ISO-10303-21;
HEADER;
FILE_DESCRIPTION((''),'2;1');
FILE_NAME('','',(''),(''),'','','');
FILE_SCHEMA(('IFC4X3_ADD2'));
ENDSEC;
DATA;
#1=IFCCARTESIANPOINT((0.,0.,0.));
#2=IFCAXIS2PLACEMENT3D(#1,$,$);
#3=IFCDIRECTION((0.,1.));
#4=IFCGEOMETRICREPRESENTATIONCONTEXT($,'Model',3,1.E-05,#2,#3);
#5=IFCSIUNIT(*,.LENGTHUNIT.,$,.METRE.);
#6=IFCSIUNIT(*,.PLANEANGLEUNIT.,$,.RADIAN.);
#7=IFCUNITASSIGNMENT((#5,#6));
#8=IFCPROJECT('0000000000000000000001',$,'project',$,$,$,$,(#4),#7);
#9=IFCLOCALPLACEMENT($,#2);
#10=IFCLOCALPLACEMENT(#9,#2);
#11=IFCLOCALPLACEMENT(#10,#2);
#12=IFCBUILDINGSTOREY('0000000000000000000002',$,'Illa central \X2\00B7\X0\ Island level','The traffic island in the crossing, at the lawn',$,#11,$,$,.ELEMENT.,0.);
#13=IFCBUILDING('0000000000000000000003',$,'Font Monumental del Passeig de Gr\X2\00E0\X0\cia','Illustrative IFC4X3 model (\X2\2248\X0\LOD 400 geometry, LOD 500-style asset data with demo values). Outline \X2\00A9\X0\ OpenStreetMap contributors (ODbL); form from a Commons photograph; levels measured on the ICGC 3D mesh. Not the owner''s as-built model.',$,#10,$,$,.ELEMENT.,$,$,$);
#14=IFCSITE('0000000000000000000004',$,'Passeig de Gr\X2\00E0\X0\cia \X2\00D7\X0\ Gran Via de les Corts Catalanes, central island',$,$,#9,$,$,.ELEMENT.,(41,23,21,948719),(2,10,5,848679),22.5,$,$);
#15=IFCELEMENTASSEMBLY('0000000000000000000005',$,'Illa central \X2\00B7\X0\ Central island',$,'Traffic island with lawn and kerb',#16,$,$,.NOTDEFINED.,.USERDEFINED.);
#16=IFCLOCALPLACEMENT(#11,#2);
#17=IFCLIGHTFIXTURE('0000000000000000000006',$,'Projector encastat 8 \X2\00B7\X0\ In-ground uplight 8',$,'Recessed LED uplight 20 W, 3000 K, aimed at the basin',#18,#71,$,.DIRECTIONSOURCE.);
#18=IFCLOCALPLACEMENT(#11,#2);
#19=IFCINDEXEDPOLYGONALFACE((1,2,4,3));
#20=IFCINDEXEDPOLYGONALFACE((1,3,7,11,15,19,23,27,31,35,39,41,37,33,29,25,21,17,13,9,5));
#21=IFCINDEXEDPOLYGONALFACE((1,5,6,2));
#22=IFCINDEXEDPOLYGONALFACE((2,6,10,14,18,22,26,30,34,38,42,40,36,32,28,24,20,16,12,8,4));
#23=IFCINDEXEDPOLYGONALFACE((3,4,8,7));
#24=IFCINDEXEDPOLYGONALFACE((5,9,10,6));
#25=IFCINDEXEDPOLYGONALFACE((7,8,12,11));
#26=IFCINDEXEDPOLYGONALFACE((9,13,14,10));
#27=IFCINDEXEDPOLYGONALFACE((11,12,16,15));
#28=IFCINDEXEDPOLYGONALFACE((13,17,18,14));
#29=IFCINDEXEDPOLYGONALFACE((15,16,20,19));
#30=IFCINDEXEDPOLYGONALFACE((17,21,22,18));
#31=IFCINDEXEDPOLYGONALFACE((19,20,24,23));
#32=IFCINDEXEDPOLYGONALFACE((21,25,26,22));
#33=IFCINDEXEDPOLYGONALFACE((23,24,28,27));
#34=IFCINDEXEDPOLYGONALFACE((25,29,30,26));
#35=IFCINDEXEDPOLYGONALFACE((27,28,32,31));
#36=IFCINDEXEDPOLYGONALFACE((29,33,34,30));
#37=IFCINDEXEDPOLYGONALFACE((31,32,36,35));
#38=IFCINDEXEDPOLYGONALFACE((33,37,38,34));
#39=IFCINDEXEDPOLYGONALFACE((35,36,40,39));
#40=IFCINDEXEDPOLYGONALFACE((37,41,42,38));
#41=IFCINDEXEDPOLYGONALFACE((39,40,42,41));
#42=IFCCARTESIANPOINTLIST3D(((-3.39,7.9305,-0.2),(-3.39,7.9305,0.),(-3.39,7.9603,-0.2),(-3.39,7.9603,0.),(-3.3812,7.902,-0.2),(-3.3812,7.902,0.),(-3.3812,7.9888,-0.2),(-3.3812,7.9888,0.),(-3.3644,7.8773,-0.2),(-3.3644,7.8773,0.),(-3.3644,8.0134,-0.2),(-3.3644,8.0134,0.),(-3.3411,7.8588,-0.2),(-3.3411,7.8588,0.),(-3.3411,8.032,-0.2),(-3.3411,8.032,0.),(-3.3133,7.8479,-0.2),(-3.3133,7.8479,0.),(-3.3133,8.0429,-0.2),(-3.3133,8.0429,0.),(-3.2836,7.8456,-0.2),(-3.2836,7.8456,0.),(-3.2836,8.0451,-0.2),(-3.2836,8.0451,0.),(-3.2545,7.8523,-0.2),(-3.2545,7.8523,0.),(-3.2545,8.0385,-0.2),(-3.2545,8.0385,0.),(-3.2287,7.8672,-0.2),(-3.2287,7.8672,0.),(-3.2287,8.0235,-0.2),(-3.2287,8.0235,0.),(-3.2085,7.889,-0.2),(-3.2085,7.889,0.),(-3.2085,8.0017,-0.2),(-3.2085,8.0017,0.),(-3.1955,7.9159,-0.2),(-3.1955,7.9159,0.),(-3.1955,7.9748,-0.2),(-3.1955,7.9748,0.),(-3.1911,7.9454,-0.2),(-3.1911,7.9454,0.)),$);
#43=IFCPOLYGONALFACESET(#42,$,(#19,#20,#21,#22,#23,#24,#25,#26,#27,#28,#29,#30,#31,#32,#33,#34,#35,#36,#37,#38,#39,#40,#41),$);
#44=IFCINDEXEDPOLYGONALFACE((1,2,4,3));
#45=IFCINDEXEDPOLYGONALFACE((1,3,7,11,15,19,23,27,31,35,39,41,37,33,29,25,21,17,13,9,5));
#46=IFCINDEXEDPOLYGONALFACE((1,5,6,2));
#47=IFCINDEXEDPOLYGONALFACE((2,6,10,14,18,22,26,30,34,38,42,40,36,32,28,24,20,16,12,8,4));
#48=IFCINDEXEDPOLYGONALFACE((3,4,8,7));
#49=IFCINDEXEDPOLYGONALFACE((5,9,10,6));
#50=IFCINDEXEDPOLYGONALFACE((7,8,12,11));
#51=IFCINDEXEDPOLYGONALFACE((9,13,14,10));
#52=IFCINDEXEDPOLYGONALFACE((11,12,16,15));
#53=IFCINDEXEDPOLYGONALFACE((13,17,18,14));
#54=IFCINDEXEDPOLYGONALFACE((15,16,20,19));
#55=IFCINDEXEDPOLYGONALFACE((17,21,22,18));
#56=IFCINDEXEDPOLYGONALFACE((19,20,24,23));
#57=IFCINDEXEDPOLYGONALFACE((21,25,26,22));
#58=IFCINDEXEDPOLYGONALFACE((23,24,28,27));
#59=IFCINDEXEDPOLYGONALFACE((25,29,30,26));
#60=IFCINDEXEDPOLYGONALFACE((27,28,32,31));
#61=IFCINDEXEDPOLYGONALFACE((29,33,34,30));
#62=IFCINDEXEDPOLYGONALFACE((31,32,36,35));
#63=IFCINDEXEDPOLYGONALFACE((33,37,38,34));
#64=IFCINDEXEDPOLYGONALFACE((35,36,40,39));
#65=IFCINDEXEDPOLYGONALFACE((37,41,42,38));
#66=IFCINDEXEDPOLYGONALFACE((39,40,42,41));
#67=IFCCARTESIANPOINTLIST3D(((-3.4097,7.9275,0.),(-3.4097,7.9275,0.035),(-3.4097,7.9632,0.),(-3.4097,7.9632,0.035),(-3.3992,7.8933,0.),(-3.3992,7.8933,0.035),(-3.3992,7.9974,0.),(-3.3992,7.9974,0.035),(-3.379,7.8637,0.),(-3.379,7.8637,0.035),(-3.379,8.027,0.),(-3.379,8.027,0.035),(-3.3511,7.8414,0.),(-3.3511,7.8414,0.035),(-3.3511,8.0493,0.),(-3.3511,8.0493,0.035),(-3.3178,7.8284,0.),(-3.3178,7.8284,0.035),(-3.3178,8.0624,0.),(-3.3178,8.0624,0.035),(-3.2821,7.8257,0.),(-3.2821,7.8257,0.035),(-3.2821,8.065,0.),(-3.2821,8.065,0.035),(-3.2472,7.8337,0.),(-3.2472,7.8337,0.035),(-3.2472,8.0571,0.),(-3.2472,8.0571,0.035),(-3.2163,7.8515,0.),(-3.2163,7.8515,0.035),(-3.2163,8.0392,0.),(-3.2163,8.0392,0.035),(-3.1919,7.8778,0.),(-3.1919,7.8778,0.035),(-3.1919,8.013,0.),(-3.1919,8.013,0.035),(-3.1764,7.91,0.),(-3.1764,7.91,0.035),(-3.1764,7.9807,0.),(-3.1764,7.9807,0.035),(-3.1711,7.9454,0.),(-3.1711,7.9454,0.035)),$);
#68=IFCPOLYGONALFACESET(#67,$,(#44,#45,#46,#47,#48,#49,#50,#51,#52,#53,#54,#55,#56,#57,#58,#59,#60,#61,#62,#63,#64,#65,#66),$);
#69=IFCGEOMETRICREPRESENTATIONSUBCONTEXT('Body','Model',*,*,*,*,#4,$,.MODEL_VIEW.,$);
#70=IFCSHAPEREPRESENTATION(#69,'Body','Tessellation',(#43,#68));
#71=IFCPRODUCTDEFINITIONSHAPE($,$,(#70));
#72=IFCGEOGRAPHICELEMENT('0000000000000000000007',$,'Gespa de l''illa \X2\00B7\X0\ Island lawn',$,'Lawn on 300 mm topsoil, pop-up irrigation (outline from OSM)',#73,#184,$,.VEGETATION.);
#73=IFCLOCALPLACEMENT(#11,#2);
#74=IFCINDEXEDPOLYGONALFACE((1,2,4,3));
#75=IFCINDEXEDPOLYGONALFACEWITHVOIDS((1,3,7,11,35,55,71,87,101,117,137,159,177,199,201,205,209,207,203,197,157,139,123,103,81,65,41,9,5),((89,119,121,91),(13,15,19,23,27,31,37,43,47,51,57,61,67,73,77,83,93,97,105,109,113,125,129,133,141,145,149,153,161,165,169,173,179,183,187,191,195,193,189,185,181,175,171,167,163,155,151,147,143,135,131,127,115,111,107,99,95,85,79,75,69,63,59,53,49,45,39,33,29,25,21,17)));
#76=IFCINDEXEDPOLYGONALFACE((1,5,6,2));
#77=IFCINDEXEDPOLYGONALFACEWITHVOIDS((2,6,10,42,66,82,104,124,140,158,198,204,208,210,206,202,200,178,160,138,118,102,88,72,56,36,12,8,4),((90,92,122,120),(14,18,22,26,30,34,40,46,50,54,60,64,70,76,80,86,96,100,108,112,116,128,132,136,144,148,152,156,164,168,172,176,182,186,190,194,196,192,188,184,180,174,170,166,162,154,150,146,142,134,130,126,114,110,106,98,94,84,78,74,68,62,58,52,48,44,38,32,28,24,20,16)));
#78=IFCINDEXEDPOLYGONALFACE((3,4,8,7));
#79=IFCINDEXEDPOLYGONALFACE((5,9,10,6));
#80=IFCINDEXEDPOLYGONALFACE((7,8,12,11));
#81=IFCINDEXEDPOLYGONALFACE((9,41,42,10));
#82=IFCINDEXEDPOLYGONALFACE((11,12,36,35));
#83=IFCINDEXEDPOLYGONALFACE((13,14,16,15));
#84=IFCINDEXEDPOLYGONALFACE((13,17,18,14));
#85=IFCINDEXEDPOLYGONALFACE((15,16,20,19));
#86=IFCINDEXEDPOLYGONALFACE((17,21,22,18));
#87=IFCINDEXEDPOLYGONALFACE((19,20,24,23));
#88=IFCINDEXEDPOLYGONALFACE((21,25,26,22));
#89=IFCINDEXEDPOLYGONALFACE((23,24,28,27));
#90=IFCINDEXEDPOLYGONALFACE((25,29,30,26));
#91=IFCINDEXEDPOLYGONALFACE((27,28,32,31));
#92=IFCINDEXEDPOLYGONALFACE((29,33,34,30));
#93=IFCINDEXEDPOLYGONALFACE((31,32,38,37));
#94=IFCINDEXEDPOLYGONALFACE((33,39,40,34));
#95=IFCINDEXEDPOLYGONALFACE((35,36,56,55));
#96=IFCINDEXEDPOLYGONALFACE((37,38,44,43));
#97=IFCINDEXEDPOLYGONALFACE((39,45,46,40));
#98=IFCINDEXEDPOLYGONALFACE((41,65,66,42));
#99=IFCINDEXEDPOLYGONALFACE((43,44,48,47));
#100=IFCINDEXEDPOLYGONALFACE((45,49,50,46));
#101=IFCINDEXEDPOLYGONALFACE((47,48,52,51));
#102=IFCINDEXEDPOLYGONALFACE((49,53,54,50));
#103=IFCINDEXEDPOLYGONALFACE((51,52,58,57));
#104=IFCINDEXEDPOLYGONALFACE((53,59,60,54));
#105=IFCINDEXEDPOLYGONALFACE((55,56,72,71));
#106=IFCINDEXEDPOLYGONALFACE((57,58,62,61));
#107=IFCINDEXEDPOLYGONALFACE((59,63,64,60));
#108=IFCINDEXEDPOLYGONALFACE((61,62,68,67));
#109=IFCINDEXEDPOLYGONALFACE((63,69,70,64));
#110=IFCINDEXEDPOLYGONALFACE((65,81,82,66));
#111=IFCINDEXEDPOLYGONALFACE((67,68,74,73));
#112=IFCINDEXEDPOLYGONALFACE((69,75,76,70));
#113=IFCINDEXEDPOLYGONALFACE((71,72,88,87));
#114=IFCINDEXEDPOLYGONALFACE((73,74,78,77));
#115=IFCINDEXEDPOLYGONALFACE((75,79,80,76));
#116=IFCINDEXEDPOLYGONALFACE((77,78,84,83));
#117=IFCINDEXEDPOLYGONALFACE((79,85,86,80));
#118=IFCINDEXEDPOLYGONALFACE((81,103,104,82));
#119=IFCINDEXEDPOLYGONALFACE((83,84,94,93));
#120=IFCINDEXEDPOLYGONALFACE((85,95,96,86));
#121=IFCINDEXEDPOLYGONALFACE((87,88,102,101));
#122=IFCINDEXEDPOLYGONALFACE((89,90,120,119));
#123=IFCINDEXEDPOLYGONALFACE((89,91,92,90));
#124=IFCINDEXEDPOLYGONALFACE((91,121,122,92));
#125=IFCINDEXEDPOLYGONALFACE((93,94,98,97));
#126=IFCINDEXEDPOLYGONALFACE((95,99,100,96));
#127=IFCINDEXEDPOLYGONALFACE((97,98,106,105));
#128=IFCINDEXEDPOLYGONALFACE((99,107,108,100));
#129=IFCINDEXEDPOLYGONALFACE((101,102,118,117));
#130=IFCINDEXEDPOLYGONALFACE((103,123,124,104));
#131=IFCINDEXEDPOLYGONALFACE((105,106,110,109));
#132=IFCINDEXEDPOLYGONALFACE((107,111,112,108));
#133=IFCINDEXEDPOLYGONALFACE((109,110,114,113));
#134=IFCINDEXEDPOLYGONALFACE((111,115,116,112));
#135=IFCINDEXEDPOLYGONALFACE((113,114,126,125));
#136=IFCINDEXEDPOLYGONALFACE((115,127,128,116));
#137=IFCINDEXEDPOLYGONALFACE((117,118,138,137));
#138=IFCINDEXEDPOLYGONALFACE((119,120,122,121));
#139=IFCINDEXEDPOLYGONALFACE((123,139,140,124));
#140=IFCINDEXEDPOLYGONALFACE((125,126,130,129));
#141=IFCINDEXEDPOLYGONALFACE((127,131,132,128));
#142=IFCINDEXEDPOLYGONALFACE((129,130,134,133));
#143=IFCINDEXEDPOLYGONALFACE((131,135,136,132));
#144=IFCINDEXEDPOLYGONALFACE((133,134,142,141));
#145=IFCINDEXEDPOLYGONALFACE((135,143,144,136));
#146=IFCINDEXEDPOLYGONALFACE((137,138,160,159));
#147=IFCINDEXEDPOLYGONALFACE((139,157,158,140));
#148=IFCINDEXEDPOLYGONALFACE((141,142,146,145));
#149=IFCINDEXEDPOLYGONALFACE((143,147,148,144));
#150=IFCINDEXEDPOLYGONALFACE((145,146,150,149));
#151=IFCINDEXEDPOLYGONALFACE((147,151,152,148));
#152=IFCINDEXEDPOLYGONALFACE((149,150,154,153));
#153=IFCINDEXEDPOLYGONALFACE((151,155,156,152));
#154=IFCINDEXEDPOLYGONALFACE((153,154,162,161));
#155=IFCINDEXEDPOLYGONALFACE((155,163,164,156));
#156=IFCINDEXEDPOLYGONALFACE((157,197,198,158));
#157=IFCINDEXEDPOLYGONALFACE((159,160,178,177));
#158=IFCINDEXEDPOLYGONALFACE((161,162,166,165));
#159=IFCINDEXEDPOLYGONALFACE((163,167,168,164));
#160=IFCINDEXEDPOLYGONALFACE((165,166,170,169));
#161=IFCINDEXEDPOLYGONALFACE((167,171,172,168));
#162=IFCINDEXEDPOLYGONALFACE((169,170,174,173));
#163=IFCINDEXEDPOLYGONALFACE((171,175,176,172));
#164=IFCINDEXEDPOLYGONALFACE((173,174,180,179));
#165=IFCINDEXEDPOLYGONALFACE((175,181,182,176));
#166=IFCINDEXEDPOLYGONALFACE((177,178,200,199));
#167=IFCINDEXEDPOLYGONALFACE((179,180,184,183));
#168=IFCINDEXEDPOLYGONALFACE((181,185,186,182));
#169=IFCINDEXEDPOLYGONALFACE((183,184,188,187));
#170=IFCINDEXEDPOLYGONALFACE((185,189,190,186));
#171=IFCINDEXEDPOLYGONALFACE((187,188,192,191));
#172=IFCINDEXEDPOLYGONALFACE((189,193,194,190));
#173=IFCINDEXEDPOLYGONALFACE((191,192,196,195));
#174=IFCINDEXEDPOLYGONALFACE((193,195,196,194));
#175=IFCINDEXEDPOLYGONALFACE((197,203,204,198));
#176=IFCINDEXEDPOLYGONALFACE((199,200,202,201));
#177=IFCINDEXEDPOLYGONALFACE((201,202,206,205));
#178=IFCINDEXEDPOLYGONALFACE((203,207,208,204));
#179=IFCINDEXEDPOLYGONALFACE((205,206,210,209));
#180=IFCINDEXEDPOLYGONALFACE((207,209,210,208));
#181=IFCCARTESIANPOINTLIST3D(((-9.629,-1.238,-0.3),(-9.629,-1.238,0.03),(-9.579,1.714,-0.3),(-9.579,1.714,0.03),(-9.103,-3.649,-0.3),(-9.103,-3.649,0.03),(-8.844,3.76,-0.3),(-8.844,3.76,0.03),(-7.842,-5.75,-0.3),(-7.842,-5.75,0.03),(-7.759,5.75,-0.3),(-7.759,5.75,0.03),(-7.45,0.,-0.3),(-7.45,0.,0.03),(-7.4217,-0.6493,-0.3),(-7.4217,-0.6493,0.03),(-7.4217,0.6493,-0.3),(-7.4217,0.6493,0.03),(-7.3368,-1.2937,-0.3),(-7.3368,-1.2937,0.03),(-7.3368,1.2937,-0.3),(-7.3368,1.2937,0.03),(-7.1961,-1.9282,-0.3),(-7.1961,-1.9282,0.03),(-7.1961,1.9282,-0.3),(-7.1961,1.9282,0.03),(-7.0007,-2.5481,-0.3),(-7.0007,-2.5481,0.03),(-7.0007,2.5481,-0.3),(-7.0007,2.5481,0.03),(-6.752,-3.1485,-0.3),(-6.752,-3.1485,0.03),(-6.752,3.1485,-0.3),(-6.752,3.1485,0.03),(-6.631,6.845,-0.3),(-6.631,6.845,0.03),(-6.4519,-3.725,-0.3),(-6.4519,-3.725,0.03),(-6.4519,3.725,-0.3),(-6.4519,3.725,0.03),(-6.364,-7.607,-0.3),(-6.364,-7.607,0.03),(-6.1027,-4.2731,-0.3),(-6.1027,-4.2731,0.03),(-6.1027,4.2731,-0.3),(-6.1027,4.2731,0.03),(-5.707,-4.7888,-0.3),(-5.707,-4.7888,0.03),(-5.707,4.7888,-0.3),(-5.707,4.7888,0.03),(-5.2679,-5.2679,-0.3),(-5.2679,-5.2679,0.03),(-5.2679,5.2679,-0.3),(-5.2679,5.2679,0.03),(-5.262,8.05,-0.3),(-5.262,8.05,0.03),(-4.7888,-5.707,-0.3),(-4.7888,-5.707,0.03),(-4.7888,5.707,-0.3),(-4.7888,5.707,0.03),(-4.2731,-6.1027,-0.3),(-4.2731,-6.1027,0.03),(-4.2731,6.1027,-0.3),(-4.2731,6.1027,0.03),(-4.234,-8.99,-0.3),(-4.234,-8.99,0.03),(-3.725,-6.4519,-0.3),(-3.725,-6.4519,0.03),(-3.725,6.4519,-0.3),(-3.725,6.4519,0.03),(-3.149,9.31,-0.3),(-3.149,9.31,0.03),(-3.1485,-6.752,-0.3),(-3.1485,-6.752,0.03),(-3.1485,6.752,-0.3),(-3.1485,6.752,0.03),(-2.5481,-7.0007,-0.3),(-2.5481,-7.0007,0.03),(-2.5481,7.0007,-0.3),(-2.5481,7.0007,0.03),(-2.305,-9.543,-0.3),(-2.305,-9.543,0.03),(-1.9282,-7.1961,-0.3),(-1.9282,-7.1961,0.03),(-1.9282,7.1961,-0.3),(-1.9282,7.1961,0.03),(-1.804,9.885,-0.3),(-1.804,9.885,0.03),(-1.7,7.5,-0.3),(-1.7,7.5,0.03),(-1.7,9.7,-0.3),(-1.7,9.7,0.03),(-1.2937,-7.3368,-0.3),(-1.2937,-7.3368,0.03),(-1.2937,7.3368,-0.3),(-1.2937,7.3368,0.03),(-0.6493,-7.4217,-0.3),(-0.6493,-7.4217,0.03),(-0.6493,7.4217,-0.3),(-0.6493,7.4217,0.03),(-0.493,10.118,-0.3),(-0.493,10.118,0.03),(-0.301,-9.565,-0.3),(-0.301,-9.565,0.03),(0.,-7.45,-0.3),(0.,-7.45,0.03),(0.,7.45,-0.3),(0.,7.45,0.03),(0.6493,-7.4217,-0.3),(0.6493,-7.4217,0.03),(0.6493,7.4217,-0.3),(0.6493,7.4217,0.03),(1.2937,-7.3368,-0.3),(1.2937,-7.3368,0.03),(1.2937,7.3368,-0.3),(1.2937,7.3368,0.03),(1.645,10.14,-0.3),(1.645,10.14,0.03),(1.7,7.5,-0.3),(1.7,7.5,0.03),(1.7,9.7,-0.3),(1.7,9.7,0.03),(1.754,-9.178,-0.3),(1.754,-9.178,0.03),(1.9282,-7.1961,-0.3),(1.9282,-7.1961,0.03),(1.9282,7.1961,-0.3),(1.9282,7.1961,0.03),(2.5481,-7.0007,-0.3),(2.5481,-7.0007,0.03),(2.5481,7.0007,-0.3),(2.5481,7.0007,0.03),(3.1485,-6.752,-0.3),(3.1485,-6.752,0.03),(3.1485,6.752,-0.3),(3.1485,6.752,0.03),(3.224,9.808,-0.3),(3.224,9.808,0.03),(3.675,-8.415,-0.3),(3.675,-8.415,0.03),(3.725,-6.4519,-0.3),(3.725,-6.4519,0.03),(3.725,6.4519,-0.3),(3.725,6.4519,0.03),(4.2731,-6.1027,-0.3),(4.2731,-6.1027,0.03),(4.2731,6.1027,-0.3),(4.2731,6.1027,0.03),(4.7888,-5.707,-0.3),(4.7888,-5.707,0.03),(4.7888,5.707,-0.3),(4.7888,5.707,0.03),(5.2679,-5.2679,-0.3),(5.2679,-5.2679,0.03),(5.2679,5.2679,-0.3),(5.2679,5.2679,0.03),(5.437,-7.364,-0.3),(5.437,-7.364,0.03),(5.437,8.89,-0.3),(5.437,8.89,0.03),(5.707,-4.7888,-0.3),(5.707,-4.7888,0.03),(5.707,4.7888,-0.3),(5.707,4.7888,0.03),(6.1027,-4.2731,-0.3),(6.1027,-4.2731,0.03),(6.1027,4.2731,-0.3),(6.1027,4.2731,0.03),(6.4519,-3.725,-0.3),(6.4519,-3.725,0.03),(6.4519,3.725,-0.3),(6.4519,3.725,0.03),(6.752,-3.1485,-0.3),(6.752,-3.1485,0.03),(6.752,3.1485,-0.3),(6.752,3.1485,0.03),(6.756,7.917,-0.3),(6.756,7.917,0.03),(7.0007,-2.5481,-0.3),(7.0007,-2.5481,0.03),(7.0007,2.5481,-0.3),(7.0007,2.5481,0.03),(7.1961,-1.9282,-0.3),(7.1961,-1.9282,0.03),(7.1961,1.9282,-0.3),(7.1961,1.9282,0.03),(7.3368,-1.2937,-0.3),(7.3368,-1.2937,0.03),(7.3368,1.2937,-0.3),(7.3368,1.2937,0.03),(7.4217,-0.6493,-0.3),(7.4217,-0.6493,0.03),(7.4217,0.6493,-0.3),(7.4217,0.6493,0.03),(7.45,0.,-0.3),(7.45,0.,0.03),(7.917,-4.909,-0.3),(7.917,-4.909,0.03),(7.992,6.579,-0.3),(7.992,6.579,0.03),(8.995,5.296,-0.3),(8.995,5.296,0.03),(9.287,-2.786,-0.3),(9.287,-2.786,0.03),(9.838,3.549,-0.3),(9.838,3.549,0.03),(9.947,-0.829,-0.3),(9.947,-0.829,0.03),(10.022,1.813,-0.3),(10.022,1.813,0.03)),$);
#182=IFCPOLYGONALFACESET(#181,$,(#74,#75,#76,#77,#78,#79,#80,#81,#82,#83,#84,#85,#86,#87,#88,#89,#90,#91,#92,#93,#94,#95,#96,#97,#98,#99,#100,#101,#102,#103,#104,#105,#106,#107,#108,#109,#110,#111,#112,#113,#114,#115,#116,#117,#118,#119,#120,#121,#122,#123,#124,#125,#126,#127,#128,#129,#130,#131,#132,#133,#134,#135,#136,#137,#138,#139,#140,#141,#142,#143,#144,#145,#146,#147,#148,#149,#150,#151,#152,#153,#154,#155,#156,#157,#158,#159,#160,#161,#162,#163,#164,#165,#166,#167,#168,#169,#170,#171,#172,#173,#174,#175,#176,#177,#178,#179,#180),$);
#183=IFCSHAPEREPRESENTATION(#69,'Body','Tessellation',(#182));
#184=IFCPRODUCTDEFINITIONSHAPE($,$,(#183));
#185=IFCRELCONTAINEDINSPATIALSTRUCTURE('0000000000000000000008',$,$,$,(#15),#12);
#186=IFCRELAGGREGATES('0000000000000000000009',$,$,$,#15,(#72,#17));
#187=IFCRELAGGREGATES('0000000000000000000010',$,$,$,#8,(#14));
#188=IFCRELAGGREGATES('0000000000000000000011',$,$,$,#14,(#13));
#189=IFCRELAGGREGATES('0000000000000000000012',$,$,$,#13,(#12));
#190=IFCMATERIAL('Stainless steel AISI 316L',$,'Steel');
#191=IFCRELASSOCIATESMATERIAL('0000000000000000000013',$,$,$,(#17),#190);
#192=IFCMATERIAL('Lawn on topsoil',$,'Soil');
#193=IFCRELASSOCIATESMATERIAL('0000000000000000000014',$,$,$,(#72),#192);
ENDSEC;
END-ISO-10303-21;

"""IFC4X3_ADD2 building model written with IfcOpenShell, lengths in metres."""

from ifc_helpers import new_model, si_unit, direction, frame, origin, origin_2d_with_axis, place, context, subcontext, project, spatial, polyline, circle, outline, extrude, material, element, aggregate, save


model = new_model("IFC4X3_ADD2")

# Units and contexts
model_context = context("Model", 3, precision=1e-05, world=origin(), true_north=direction((0.0, 1.0)))
body_context = subcontext(model_context, "Body", "Model", "MODEL_VIEW")
ifc_project = project(units=[si_unit("LENGTHUNIT", "METRE"), si_unit("PLANEANGLEUNIT", "RADIAN")], contexts=[model_context])

# Site, building, storey
site_placement = place(None, origin())
site = spatial("IfcSite", under=ifc_project, at=site_placement, Name="Passeig de Gràcia × Gran Via de les Corts Catalanes, central island", CompositionType="ELEMENT", RefLatitude=(41, 23, 21, 948719), RefLongitude=(2, 10, 5, 848679), RefElevation=22.5)
building_placement = place(site_placement, origin())
building = spatial("IfcBuilding", under=site, at=building_placement, Name="Font Monumental del Passeig de Gràcia", Description="Illustrative IFC4X3 model (≈LOD 400 geometry, LOD 500-style asset data with demo values). Outline © OpenStreetMap contributors (ODbL); form from a Commons photograph; levels measured on the ICGC 3D mesh. Not the owner's as-built model.", CompositionType="ELEMENT")
storey_placement = place(building_placement, origin())
storey = spatial("IfcBuildingStorey", under=building, at=storey_placement, Name="Illa central · Island level", Description="The traffic island in the crossing, at the lawn", CompositionType="ELEMENT", Elevation=0.0)

# Shared definitions
ifc_material_1 = material(Name="Stainless steel AISI 316L", Category="Steel")

# Element assembly, light fixture
assembly_1_placement = place(building_placement, origin())
assembly_1 = element("IfcElementAssembly", 1, at=assembly_1_placement, inside=storey, Name="Illa central · Central island", ObjectType="Traffic island with lawn and kerb", AssemblyPlace="NOTDEFINED", PredefinedType="USERDEFINED")
light_fixture_1_placement = place(building_placement, origin())
light_fixture_1 = element("IfcLightFixture", 2, at=light_fixture_1_placement, material=ifc_material_1, Name="Projector encastat 8 · In-ground uplight 8", ObjectType="Recessed LED uplight 20 W, 3000 K, aimed at the basin", PredefinedType="DIRECTIONSOURCE", context=body_context, shape_type="SweptSolid", body=[
    extrude(circle(Radius=0.1, at=origin_2d_with_axis()), frame((-3.2911, 7.9454, -0.2)), (0.0, 0.0, 1.0), 0.2),
    extrude(circle(Radius=0.12, at=origin_2d_with_axis()), frame((-3.2911, 7.9454, 0.0)), (0.0, 0.0, 1.0), 0.035),
])

# Geographic element
ifc_material_2 = material(Name="Lawn on topsoil", Category="Soil")
geographic_element_placement = place(building_placement, origin())
geographic_element = element("IfcGeographicElement", 3, at=geographic_element_placement, material=ifc_material_2, Name="Gespa de l'illa · Island lawn", ObjectType="Lawn on 300 mm topsoil, pop-up irrigation (outline from OSM)", PredefinedType="VEGETATION", context=body_context, shape_type="SweptSolid", body=[
    extrude(outline(polyline([(-1.804, 9.885), (-3.149, 9.31), (-5.262, 8.05), (-6.631, 6.845), (-7.759, 5.75), (-8.844, 3.76), (-9.579, 1.714), (-9.629, -1.238), (-9.103, -3.649), (-7.842, -5.75), (-6.364, -7.607), (-4.234, -8.99), (-2.305, -9.543), (-0.301, -9.565), (1.754, -9.178), (3.675, -8.415), (5.437, -7.364), (7.917, -4.909), (9.287, -2.786), (9.947, -0.829), (10.022, 1.813), (9.838, 3.549), (8.995, 5.296), (7.992, 6.579), (6.756, 7.917), (5.437, 8.89), (3.224, 9.808), (1.645, 10.14), (-0.493, 10.118), (-1.804, 9.885)]), holes=[polyline([(-0.6493, 7.4217), (-1.2937, 7.3368), (-1.9282, 7.1961), (-2.5481, 7.0007), (-3.1485, 6.752), (-3.725, 6.4519), (-4.2731, 6.1027), (-4.7888, 5.707), (-5.2679, 5.2679), (-5.707, 4.7888), (-6.1027, 4.2731), (-6.4519, 3.725), (-6.752, 3.1485), (-7.0007, 2.5481), (-7.1961, 1.9282), (-7.3368, 1.2937), (-7.4217, 0.6493), (-7.45, 0.0), (-7.4217, -0.6493), (-7.3368, -1.2937), (-7.1961, -1.9282), (-7.0007, -2.5481), (-6.752, -3.1485), (-6.4519, -3.725), (-6.1027, -4.2731), (-5.707, -4.7888), (-5.2679, -5.2679), (-4.7888, -5.707), (-4.2731, -6.1027), (-3.725, -6.4519), (-3.1485, -6.752), (-2.5481, -7.0007), (-1.9282, -7.1961), (-1.2937, -7.3368), (-0.6493, -7.4217), (0.0, -7.45), (0.6493, -7.4217), (1.2937, -7.3368), (1.9282, -7.1961), (2.5481, -7.0007), (3.1485, -6.752), (3.725, -6.4519), (4.2731, -6.1027), (4.7888, -5.707), (5.2679, -5.2679), (5.707, -4.7888), (6.1027, -4.2731), (6.4519, -3.725), (6.752, -3.1485), (7.0007, -2.5481), (7.1961, -1.9282), (7.3368, -1.2937), (7.4217, -0.6493), (7.45, 0.0), (7.4217, 0.6493), (7.3368, 1.2937), (7.1961, 1.9282), (7.0007, 2.5481), (6.752, 3.1485), (6.4519, 3.725), (6.1027, 4.2731), (5.707, 4.7888), (5.2679, 5.2679), (4.7888, 5.707), (4.2731, 6.1027), (3.725, 6.4519), (3.1485, 6.752), (2.5481, 7.0007), (1.9282, 7.1961), (1.2937, 7.3368), (0.6493, 7.4217), (0.0, 7.45), (-0.6493, 7.4217)]), polyline([(-1.7, 7.5), (-1.7, 9.7), (1.7, 9.7), (1.7, 7.5), (-1.7, 7.5)])]), frame((0.0, 0.0, -0.3)), (0.0, 0.0, 1.0), 0.33),
])

aggregate(assembly_1, [geographic_element, light_fixture_1])

save(model, "model.ifc")
